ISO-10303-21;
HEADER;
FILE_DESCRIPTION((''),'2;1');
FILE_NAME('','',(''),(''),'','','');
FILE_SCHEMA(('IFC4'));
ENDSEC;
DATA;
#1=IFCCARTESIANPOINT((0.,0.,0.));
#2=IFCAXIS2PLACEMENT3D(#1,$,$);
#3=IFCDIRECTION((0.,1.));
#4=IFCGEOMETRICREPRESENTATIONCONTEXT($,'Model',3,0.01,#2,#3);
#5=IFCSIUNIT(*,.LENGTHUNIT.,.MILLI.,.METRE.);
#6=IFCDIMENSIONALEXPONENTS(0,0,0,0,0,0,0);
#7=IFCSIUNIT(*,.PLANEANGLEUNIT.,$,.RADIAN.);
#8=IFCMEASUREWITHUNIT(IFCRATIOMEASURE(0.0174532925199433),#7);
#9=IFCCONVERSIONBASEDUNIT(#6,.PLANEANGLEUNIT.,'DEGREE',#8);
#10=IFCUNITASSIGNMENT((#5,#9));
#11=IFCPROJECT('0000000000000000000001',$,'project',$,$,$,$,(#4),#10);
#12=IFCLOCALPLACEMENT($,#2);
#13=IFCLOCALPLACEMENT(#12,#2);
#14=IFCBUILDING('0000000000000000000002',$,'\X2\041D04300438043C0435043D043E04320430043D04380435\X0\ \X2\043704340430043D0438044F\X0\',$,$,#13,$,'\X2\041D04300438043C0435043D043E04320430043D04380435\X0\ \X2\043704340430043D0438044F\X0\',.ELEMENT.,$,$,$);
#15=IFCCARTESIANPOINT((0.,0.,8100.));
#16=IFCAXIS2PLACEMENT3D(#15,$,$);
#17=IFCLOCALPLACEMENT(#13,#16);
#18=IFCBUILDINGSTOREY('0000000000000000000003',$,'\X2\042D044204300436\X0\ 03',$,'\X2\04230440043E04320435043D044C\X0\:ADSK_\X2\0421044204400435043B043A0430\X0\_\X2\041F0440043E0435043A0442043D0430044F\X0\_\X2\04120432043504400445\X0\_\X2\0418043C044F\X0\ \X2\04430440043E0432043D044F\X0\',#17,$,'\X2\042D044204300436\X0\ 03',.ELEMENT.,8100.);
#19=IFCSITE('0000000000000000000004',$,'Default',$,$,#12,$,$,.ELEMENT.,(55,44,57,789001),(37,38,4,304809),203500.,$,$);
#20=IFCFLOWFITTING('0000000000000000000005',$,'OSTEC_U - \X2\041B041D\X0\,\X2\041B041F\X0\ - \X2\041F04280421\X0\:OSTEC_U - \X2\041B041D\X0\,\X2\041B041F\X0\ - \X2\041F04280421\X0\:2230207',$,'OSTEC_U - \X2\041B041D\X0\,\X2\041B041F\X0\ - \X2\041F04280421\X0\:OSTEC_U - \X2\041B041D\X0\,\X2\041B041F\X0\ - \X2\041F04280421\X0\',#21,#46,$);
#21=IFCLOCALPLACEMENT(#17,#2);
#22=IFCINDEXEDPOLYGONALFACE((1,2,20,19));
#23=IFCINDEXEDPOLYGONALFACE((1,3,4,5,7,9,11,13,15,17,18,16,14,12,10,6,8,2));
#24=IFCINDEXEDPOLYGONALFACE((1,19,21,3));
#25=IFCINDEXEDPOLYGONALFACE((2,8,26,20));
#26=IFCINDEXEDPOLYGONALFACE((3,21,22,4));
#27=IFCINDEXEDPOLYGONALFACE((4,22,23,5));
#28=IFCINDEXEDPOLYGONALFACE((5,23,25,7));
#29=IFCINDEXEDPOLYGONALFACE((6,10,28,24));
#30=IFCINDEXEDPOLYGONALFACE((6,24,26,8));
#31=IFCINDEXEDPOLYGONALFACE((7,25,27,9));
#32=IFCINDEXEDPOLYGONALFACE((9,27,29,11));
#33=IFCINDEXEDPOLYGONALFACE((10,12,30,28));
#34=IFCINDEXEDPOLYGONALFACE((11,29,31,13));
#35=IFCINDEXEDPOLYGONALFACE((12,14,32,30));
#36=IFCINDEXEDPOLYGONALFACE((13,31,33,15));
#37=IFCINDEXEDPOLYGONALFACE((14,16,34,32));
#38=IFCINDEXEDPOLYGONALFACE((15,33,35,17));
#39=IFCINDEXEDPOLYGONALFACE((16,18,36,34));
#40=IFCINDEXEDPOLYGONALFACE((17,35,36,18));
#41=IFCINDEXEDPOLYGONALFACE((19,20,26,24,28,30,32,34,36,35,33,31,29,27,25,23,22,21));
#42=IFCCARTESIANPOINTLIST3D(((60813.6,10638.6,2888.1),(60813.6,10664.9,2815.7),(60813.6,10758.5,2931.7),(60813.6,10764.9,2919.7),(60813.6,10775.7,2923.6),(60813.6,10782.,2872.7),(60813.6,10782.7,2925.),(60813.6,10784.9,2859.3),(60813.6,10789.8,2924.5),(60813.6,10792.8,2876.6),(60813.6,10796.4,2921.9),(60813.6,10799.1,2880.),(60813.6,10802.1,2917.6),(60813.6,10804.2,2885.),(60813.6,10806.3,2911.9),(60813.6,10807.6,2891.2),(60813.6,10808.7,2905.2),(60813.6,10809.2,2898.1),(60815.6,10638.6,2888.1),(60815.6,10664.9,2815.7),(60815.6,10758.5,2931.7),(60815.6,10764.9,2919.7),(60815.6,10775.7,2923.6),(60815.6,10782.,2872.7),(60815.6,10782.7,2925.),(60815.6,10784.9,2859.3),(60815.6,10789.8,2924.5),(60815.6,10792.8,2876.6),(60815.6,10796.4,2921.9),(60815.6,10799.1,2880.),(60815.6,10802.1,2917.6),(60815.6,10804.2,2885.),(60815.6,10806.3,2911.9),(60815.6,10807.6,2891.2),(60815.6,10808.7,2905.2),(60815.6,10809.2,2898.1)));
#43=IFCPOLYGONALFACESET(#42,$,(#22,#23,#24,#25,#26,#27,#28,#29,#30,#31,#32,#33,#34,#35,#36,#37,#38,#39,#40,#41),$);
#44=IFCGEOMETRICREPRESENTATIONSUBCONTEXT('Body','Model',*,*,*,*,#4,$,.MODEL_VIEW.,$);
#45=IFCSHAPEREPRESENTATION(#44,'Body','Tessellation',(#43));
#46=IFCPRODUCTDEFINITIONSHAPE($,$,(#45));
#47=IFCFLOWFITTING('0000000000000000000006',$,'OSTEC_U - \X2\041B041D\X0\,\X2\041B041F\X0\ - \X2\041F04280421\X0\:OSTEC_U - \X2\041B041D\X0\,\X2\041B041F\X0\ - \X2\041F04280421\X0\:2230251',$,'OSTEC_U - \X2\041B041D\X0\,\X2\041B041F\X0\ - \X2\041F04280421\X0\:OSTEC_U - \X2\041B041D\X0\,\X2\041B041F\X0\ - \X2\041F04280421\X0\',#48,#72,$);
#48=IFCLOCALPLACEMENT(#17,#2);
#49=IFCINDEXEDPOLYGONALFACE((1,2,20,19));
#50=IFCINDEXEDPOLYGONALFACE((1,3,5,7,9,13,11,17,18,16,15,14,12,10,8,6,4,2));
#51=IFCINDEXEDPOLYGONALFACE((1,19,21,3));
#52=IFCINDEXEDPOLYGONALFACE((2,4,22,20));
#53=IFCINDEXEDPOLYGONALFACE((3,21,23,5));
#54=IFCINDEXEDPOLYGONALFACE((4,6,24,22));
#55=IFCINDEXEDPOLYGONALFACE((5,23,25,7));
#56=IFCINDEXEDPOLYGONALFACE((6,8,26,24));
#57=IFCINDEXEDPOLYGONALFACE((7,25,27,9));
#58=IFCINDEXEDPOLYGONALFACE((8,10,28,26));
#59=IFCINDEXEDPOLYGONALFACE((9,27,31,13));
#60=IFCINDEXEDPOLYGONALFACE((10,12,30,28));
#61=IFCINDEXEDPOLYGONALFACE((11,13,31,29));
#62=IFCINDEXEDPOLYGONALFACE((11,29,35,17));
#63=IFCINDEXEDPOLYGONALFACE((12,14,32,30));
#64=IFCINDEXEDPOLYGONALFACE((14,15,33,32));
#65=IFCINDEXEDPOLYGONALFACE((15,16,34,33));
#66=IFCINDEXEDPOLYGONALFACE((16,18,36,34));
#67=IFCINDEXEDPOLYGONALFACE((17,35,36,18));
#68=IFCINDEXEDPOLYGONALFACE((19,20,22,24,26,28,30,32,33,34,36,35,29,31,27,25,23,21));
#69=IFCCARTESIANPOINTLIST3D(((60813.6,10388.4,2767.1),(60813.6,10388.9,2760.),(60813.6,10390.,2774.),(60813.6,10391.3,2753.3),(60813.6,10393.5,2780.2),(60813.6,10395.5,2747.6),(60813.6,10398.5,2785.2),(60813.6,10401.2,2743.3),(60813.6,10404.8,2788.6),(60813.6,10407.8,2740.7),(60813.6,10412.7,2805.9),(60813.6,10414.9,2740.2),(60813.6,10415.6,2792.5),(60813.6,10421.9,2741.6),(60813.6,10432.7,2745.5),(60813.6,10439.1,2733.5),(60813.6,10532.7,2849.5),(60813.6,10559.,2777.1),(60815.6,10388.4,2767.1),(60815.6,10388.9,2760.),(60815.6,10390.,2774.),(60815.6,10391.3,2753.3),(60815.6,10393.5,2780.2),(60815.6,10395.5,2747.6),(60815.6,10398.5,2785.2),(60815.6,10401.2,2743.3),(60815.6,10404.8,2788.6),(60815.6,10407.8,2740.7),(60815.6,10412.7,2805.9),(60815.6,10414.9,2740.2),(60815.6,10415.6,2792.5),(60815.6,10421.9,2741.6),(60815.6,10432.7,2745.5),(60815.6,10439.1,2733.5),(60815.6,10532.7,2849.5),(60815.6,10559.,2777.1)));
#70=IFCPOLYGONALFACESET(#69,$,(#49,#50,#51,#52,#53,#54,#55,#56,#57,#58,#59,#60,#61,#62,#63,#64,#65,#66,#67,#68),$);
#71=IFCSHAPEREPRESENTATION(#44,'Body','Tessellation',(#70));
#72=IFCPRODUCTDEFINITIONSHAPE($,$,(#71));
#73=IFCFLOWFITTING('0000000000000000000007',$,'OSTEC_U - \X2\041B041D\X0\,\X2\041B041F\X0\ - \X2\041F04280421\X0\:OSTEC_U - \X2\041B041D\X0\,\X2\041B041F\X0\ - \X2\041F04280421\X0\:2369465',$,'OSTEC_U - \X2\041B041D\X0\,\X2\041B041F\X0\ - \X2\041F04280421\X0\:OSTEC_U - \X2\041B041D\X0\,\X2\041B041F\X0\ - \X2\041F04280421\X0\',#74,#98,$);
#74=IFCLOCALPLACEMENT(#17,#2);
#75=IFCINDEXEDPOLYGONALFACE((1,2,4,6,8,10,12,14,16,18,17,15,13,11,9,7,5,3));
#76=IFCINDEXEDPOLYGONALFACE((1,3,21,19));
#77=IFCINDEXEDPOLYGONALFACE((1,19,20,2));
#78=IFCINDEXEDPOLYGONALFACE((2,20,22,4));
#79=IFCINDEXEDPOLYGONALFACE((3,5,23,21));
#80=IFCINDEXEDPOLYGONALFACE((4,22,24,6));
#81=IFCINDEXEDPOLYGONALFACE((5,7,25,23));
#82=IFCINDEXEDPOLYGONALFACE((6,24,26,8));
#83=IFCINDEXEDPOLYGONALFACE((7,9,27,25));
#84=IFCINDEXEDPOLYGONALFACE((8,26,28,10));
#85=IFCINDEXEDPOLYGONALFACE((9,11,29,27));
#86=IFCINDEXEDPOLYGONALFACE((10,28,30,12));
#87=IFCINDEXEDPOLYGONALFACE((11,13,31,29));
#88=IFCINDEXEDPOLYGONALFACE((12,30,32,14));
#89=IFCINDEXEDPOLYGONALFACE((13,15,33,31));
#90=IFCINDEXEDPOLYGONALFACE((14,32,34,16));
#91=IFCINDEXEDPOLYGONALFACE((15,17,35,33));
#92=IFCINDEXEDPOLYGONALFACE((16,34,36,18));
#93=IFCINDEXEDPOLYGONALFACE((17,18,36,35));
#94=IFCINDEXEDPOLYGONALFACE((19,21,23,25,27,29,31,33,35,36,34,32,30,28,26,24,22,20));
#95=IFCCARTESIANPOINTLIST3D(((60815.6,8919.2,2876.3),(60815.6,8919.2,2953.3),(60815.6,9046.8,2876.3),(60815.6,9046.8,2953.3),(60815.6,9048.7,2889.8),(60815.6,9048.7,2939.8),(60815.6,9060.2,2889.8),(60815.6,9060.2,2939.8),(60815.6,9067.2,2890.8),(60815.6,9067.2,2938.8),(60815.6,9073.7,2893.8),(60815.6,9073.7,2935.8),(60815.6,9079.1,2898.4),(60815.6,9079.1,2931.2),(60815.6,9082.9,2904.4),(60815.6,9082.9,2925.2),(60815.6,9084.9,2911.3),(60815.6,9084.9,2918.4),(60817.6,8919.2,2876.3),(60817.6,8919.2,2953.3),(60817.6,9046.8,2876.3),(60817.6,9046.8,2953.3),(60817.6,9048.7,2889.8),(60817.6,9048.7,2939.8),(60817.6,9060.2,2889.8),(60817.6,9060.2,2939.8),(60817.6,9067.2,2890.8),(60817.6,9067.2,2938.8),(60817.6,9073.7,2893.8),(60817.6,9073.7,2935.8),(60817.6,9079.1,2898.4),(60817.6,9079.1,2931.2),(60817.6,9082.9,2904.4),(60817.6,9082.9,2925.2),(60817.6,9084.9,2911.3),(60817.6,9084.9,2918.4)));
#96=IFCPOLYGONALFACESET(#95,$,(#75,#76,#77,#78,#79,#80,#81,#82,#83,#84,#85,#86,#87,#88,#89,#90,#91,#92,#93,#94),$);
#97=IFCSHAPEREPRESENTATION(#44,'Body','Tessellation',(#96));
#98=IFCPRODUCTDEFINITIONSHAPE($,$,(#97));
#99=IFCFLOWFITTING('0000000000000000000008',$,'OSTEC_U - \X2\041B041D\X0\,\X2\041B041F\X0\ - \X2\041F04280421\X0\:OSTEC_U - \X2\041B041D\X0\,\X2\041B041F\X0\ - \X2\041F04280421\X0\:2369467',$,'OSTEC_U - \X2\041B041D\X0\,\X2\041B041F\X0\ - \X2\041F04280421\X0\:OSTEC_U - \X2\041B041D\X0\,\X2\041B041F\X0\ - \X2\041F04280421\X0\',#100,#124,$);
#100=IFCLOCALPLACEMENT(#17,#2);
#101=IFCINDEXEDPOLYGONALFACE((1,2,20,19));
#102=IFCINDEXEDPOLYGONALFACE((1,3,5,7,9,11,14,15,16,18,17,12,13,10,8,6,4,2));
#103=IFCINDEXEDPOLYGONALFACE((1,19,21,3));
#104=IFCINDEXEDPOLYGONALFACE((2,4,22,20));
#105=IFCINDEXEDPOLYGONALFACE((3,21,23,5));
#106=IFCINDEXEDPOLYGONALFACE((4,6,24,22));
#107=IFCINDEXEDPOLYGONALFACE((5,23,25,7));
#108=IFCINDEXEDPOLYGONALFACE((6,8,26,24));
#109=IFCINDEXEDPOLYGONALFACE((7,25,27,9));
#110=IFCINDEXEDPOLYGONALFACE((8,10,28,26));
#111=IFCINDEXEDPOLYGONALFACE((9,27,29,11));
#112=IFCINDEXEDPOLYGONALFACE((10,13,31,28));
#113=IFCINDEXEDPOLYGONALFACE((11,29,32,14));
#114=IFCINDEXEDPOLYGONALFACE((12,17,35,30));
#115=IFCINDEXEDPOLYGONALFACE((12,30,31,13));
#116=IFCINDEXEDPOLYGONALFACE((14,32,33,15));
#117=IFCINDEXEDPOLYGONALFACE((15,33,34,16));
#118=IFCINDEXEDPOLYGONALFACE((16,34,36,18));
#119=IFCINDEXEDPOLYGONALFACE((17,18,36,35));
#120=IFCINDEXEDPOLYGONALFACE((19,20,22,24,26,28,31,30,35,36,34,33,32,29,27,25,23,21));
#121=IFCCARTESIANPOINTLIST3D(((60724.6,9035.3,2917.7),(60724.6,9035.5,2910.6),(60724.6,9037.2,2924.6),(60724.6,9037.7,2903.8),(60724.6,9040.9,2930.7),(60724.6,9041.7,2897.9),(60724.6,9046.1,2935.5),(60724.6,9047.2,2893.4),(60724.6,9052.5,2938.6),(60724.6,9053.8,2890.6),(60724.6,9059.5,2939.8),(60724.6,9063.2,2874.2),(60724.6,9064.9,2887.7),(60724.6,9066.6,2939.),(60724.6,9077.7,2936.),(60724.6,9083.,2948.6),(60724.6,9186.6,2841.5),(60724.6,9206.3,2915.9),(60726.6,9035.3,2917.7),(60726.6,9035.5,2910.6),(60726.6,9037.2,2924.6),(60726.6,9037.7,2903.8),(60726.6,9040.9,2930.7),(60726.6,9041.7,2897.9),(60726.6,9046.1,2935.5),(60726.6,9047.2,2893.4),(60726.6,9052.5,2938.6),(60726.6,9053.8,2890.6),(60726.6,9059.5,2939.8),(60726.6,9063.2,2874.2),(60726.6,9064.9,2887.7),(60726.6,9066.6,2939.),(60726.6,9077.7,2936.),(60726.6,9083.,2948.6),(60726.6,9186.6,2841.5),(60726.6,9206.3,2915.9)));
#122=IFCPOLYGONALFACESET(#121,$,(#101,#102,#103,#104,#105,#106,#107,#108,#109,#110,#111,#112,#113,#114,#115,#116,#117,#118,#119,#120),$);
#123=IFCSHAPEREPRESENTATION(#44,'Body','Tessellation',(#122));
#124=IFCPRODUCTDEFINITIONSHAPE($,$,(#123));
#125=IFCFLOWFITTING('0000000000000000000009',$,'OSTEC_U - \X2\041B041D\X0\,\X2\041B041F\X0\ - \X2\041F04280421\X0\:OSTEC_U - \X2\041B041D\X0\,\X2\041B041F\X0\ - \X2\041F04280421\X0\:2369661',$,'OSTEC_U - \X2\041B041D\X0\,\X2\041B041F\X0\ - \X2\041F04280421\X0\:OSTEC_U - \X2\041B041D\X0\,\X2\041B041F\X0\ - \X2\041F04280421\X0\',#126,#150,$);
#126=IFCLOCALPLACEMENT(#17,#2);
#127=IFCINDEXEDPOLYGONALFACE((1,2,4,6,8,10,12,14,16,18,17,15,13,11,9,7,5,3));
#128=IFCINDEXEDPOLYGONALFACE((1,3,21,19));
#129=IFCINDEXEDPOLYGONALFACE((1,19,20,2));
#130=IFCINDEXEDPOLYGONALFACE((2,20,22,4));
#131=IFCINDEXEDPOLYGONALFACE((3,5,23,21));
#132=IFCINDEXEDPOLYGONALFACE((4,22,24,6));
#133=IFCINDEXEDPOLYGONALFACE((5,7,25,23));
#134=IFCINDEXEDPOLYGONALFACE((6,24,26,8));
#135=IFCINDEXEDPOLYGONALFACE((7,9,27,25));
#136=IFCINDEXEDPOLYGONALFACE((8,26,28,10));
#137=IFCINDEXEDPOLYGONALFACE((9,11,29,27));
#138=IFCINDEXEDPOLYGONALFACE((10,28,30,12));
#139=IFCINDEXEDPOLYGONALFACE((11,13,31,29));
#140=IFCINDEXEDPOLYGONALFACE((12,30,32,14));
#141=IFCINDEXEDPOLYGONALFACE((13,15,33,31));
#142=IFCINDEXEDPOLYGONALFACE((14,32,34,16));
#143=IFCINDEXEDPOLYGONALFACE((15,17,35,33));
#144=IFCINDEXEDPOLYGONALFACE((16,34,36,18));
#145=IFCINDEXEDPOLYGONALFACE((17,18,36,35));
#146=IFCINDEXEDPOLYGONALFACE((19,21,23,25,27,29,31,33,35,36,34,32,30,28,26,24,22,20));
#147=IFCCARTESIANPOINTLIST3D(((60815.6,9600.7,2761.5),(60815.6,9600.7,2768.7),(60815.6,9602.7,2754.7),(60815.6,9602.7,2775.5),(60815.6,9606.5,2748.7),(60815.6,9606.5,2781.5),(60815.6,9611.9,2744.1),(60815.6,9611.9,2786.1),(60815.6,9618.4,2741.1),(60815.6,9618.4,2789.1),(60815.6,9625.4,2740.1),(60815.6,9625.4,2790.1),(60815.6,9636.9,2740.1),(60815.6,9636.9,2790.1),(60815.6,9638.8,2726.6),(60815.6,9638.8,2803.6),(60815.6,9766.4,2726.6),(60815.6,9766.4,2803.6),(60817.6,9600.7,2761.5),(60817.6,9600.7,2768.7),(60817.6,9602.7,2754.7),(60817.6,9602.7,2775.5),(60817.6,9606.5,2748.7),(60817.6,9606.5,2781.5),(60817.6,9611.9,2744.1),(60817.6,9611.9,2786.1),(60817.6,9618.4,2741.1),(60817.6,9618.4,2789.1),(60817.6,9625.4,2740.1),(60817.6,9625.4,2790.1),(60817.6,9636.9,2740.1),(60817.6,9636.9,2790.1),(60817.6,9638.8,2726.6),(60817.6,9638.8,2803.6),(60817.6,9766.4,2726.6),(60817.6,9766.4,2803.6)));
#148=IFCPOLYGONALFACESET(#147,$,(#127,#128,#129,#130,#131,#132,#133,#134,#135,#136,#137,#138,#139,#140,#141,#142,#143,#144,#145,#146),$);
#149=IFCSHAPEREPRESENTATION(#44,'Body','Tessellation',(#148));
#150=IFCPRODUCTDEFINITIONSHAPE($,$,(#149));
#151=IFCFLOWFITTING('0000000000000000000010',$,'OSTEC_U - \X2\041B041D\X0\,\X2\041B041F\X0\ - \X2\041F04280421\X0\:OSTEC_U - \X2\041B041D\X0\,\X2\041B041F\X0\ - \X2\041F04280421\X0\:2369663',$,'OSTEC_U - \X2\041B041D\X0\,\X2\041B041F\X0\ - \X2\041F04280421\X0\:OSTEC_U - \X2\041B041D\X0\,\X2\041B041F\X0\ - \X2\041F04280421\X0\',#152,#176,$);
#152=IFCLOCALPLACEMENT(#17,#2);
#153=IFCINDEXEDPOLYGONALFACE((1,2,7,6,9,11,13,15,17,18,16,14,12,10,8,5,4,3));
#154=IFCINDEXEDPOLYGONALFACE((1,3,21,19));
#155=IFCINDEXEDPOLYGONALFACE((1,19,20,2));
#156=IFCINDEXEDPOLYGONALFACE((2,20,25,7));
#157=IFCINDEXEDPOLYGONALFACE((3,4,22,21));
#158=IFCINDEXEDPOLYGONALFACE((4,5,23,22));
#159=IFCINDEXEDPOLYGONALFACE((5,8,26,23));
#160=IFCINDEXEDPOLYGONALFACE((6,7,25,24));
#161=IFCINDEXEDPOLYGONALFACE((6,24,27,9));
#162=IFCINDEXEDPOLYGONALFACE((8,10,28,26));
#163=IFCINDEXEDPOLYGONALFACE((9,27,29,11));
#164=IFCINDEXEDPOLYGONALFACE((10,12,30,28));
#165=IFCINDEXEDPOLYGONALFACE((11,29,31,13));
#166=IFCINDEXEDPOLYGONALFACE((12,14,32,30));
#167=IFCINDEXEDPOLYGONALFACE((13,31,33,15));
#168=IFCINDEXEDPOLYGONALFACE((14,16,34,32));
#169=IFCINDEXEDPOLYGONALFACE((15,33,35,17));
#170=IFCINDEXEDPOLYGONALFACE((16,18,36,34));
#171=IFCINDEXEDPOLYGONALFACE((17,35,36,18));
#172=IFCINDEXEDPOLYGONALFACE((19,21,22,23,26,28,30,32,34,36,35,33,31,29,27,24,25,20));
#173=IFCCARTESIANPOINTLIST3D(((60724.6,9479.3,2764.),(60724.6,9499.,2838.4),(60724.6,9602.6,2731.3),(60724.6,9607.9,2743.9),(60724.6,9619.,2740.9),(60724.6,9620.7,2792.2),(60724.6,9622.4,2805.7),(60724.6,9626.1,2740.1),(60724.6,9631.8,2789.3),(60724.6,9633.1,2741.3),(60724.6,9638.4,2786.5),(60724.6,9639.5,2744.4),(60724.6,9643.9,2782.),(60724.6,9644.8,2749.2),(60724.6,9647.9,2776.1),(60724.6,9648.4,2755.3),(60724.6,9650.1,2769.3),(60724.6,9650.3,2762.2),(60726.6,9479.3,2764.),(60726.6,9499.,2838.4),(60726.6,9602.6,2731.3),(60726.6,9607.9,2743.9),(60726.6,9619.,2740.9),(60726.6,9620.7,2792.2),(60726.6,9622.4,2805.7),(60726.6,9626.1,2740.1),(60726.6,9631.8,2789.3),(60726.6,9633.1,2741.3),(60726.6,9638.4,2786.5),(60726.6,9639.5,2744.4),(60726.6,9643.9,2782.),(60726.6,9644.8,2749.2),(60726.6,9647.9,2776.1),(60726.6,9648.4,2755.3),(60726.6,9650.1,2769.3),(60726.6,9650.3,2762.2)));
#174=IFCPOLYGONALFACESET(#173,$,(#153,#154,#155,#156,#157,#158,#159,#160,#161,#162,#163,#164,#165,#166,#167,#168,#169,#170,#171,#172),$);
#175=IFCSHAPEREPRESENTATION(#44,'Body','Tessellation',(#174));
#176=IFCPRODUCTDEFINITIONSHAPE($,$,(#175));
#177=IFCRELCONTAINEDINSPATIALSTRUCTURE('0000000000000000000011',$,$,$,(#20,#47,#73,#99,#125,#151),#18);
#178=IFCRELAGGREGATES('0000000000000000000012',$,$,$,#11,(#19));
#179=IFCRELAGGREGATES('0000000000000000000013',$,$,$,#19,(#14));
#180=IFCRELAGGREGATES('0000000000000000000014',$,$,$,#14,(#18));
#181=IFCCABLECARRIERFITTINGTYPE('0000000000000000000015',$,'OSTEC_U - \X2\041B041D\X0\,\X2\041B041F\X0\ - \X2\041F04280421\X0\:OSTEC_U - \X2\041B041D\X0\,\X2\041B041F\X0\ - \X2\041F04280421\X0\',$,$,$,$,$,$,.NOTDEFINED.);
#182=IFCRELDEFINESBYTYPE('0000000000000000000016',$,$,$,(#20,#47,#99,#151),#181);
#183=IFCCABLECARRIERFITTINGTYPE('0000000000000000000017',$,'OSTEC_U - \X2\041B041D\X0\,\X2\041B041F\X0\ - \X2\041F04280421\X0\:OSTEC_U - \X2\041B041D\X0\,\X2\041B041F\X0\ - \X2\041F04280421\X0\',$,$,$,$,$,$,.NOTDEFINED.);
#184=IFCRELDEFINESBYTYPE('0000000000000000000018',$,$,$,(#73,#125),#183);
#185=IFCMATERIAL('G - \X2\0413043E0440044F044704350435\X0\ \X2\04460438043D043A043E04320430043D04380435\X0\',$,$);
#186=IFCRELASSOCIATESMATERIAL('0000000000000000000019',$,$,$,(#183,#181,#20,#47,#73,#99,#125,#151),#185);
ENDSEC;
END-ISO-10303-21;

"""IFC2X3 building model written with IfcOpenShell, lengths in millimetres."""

from ifc_helpers import new_model, entity, si_unit, converted_unit, direction, frame, frame_2d, origin, place, context, subcontext, project, spatial, polyline, circle_curve, parameter, trimmed, segment, composite_curve, outline, extrude, source, transform, mapped, material, type_object, type_shapes, element, save


model = new_model("IFC2X3")

# Units and contexts
model_context = context("Model", 3, precision=0.01, world=origin(), true_north=direction((0.0, 1.0)))
body_context = subcontext(model_context, "Body", "Model", "MODEL_VIEW")
ifc_project = project(units=[si_unit("LENGTHUNIT", "METRE", prefix="MILLI"), converted_unit("PLANEANGLEUNIT", "DEGREE", entity("IfcRatioMeasure", 0.0174532925199433), si_unit("PLANEANGLEUNIT", "RADIAN"), dimensions=[0, 0, 0, 0, 0, 0, 0])], contexts=[model_context])

# Site, building, storey
site_placement = place(None, origin())
site = spatial("IfcSite", under=ifc_project, at=site_placement, Name="Default", CompositionType="ELEMENT", RefLatitude=(55, 44, 57, 789001), RefLongitude=(37, 38, 4, 304809), RefElevation=203500.0)
building_placement = place(site_placement, origin())
building = spatial("IfcBuilding", under=site, at=building_placement, Name="Наименование здания", LongName="Наименование здания", CompositionType="ELEMENT")
storey_placement = place(building_placement, frame((0.0, 0.0, 8100.0)))
storey = spatial("IfcBuildingStorey", under=building, at=storey_placement, Name="Этаж 03", ObjectType="Уровень:ADSK_Стрелка_Проектная_Вверх_Имя уровня", LongName="Этаж 03", CompositionType="ELEMENT", Elevation=8100.0)

# Flow fittings
ifc_material_1 = material(Name="G - Горячее цинкование")
cable_carrier_fitting_type_1 = type_object("IfcCableCarrierFittingType", Name="OSTEC_U - ЛН,ЛП - ПШС:OSTEC_U - ЛН,ЛП - ПШС", PredefinedType="NOTDEFINED", material=ifc_material_1)
shared_shape_1 = source(origin(), body_context, "Body", "SweptSolid", [
    extrude(outline(composite_curve([segment(trimmed(circle_curve(frame_2d((-41.5, 0.0), x_axis=(1.0, 0.0)), 25.0), [parameter(90.0)], [parameter(270.0)], True, "PARAMETER"), True, "CONTINUOUS"), segment(polyline([(-41.5, -25.0), (-30.0, -25.0)]), True, "CONTINUOUS"), segment(polyline([(-30.0, -25.0), (-28.1, -38.5)]), True, "CONTINUOUS"), segment(polyline([(-28.1, -38.5), (99.5, -38.5)]), True, "CONTINUOUS"), segment(polyline([(99.5, -38.5), (99.5, 38.5)]), True, "CONTINUOUS"), segment(polyline([(99.5, 38.5), (-28.1, 38.5)]), True, "CONTINUOUS"), segment(polyline([(-28.1, 38.5), (-30.0, 25.0)]), True, "CONTINUOUS"), segment(polyline([(-30.0, 25.0), (-41.5, 25.0)]), True, "CONTINUOUS")], self_intersect=False)), frame((41.5, 0.0, 0.0), z_axis=(0.0, 0.0, -1.0), x_axis=(1.0, 0.0, 0.0)), (0.0, 0.0, -1.0), 2.0),
])
type_shapes(cable_carrier_fitting_type_1, [shared_shape_1])
cable_carrier_fitting_type_2 = type_object("IfcCableCarrierFittingType", Name="OSTEC_U - ЛН,ЛП - ПШС:OSTEC_U - ЛН,ЛП - ПШС", PredefinedType="NOTDEFINED", material=ifc_material_1)
type_shapes(cable_carrier_fitting_type_2, [shared_shape_1])
for number, where, z_axis, x_axis, name in (
    (1, (60813.6, 10784.3, 2900.1), (1.0, 0.0, 0.0), (0.0, -0.939693, -0.34202), "OSTEC_U - ЛН,ЛП - ПШС:OSTEC_U - ЛН,ЛП - ПШС:2230207"),
    (2, (60813.6, 10413.4, 2765.1), (1.0, 0.0, 0.0), (0.0, 0.939693, 0.34202), "OSTEC_U - ЛН,ЛП - ПШС:OSTEC_U - ЛН,ЛП - ПШС:2230251"),
):
    element("IfcFlowFitting", number, at=place(storey_placement, frame(where, z_axis=z_axis, x_axis=x_axis)), inside=storey, type_object=cable_carrier_fitting_type_2, material=ifc_material_1, Name=name, ObjectType="OSTEC_U - ЛН,ЛП - ПШС:OSTEC_U - ЛН,ЛП - ПШС", context=body_context, shape_type="MappedRepresentation", body=[
        mapped(shared_shape_1, transform((0.0, 0.0, 0.0), scale=1.0)),
    ])
flow_fitting_1_placement = place(storey_placement, frame((60815.6, 9060.2, 2914.8), z_axis=(1.0, 0.0, 0.0), x_axis=(0.0, -1.0, 0.0)))
element("IfcFlowFitting", 3, at=flow_fitting_1_placement, inside=storey, type_object=cable_carrier_fitting_type_1, material=ifc_material_1, Name="OSTEC_U - ЛН,ЛП - ПШС:OSTEC_U - ЛН,ЛП - ПШС:2369465", ObjectType="OSTEC_U - ЛН,ЛП - ПШС:OSTEC_U - ЛН,ЛП - ПШС", context=body_context, shape_type="MappedRepresentation", body=[
    mapped(shared_shape_1, transform((0.0, 0.0, 0.0), scale=1.0)),
])
flow_fitting_2_placement = place(storey_placement, frame((60726.7, 9060.2, 2914.8), z_axis=(-1.0, 0.0, 0.0), x_axis=(0.0, 0.966668, -0.256034)))
element("IfcFlowFitting", 4, at=flow_fitting_2_placement, inside=storey, type_object=cable_carrier_fitting_type_2, material=ifc_material_1, Name="OSTEC_U - ЛН,ЛП - ПШС:OSTEC_U - ЛН,ЛП - ПШС:2369467", ObjectType="OSTEC_U - ЛН,ЛП - ПШС:OSTEC_U - ЛН,ЛП - ПШС", context=body_context, shape_type="MappedRepresentation", body=[
    mapped(shared_shape_1, transform((0.0, 0.0, 0.0), scale=1.0)),
])
flow_fitting_3_placement = place(storey_placement, frame((60815.6, 9625.4, 2765.1), z_axis=(1.0, 0.0, 0.0), x_axis=(0.0, 1.0, -0.000005)))
element("IfcFlowFitting", 5, at=flow_fitting_3_placement, inside=storey, type_object=cable_carrier_fitting_type_1, material=ifc_material_1, Name="OSTEC_U - ЛН,ЛП - ПШС:OSTEC_U - ЛН,ЛП - ПШС:2369661", ObjectType="OSTEC_U - ЛН,ЛП - ПШС:OSTEC_U - ЛН,ЛП - ПШС", context=body_context, shape_type="MappedRepresentation", body=[
    mapped(shared_shape_1, transform((0.0, 0.0, 0.0), scale=1.0)),
])
flow_fitting_4_placement = place(storey_placement, frame((60726.7, 9625.4, 2765.1), z_axis=(-1.0, 0.0, 0.0), x_axis=(0.0, -0.966668, 0.256034)))
element("IfcFlowFitting", 6, at=flow_fitting_4_placement, inside=storey, type_object=cable_carrier_fitting_type_2, material=ifc_material_1, Name="OSTEC_U - ЛН,ЛП - ПШС:OSTEC_U - ЛН,ЛП - ПШС:2369663", ObjectType="OSTEC_U - ЛН,ЛП - ПШС:OSTEC_U - ЛН,ЛП - ПШС", context=body_context, shape_type="MappedRepresentation", body=[
    mapped(shared_shape_1, transform((0.0, 0.0, 0.0), scale=1.0)),
])

save(model, "model.ifc")
